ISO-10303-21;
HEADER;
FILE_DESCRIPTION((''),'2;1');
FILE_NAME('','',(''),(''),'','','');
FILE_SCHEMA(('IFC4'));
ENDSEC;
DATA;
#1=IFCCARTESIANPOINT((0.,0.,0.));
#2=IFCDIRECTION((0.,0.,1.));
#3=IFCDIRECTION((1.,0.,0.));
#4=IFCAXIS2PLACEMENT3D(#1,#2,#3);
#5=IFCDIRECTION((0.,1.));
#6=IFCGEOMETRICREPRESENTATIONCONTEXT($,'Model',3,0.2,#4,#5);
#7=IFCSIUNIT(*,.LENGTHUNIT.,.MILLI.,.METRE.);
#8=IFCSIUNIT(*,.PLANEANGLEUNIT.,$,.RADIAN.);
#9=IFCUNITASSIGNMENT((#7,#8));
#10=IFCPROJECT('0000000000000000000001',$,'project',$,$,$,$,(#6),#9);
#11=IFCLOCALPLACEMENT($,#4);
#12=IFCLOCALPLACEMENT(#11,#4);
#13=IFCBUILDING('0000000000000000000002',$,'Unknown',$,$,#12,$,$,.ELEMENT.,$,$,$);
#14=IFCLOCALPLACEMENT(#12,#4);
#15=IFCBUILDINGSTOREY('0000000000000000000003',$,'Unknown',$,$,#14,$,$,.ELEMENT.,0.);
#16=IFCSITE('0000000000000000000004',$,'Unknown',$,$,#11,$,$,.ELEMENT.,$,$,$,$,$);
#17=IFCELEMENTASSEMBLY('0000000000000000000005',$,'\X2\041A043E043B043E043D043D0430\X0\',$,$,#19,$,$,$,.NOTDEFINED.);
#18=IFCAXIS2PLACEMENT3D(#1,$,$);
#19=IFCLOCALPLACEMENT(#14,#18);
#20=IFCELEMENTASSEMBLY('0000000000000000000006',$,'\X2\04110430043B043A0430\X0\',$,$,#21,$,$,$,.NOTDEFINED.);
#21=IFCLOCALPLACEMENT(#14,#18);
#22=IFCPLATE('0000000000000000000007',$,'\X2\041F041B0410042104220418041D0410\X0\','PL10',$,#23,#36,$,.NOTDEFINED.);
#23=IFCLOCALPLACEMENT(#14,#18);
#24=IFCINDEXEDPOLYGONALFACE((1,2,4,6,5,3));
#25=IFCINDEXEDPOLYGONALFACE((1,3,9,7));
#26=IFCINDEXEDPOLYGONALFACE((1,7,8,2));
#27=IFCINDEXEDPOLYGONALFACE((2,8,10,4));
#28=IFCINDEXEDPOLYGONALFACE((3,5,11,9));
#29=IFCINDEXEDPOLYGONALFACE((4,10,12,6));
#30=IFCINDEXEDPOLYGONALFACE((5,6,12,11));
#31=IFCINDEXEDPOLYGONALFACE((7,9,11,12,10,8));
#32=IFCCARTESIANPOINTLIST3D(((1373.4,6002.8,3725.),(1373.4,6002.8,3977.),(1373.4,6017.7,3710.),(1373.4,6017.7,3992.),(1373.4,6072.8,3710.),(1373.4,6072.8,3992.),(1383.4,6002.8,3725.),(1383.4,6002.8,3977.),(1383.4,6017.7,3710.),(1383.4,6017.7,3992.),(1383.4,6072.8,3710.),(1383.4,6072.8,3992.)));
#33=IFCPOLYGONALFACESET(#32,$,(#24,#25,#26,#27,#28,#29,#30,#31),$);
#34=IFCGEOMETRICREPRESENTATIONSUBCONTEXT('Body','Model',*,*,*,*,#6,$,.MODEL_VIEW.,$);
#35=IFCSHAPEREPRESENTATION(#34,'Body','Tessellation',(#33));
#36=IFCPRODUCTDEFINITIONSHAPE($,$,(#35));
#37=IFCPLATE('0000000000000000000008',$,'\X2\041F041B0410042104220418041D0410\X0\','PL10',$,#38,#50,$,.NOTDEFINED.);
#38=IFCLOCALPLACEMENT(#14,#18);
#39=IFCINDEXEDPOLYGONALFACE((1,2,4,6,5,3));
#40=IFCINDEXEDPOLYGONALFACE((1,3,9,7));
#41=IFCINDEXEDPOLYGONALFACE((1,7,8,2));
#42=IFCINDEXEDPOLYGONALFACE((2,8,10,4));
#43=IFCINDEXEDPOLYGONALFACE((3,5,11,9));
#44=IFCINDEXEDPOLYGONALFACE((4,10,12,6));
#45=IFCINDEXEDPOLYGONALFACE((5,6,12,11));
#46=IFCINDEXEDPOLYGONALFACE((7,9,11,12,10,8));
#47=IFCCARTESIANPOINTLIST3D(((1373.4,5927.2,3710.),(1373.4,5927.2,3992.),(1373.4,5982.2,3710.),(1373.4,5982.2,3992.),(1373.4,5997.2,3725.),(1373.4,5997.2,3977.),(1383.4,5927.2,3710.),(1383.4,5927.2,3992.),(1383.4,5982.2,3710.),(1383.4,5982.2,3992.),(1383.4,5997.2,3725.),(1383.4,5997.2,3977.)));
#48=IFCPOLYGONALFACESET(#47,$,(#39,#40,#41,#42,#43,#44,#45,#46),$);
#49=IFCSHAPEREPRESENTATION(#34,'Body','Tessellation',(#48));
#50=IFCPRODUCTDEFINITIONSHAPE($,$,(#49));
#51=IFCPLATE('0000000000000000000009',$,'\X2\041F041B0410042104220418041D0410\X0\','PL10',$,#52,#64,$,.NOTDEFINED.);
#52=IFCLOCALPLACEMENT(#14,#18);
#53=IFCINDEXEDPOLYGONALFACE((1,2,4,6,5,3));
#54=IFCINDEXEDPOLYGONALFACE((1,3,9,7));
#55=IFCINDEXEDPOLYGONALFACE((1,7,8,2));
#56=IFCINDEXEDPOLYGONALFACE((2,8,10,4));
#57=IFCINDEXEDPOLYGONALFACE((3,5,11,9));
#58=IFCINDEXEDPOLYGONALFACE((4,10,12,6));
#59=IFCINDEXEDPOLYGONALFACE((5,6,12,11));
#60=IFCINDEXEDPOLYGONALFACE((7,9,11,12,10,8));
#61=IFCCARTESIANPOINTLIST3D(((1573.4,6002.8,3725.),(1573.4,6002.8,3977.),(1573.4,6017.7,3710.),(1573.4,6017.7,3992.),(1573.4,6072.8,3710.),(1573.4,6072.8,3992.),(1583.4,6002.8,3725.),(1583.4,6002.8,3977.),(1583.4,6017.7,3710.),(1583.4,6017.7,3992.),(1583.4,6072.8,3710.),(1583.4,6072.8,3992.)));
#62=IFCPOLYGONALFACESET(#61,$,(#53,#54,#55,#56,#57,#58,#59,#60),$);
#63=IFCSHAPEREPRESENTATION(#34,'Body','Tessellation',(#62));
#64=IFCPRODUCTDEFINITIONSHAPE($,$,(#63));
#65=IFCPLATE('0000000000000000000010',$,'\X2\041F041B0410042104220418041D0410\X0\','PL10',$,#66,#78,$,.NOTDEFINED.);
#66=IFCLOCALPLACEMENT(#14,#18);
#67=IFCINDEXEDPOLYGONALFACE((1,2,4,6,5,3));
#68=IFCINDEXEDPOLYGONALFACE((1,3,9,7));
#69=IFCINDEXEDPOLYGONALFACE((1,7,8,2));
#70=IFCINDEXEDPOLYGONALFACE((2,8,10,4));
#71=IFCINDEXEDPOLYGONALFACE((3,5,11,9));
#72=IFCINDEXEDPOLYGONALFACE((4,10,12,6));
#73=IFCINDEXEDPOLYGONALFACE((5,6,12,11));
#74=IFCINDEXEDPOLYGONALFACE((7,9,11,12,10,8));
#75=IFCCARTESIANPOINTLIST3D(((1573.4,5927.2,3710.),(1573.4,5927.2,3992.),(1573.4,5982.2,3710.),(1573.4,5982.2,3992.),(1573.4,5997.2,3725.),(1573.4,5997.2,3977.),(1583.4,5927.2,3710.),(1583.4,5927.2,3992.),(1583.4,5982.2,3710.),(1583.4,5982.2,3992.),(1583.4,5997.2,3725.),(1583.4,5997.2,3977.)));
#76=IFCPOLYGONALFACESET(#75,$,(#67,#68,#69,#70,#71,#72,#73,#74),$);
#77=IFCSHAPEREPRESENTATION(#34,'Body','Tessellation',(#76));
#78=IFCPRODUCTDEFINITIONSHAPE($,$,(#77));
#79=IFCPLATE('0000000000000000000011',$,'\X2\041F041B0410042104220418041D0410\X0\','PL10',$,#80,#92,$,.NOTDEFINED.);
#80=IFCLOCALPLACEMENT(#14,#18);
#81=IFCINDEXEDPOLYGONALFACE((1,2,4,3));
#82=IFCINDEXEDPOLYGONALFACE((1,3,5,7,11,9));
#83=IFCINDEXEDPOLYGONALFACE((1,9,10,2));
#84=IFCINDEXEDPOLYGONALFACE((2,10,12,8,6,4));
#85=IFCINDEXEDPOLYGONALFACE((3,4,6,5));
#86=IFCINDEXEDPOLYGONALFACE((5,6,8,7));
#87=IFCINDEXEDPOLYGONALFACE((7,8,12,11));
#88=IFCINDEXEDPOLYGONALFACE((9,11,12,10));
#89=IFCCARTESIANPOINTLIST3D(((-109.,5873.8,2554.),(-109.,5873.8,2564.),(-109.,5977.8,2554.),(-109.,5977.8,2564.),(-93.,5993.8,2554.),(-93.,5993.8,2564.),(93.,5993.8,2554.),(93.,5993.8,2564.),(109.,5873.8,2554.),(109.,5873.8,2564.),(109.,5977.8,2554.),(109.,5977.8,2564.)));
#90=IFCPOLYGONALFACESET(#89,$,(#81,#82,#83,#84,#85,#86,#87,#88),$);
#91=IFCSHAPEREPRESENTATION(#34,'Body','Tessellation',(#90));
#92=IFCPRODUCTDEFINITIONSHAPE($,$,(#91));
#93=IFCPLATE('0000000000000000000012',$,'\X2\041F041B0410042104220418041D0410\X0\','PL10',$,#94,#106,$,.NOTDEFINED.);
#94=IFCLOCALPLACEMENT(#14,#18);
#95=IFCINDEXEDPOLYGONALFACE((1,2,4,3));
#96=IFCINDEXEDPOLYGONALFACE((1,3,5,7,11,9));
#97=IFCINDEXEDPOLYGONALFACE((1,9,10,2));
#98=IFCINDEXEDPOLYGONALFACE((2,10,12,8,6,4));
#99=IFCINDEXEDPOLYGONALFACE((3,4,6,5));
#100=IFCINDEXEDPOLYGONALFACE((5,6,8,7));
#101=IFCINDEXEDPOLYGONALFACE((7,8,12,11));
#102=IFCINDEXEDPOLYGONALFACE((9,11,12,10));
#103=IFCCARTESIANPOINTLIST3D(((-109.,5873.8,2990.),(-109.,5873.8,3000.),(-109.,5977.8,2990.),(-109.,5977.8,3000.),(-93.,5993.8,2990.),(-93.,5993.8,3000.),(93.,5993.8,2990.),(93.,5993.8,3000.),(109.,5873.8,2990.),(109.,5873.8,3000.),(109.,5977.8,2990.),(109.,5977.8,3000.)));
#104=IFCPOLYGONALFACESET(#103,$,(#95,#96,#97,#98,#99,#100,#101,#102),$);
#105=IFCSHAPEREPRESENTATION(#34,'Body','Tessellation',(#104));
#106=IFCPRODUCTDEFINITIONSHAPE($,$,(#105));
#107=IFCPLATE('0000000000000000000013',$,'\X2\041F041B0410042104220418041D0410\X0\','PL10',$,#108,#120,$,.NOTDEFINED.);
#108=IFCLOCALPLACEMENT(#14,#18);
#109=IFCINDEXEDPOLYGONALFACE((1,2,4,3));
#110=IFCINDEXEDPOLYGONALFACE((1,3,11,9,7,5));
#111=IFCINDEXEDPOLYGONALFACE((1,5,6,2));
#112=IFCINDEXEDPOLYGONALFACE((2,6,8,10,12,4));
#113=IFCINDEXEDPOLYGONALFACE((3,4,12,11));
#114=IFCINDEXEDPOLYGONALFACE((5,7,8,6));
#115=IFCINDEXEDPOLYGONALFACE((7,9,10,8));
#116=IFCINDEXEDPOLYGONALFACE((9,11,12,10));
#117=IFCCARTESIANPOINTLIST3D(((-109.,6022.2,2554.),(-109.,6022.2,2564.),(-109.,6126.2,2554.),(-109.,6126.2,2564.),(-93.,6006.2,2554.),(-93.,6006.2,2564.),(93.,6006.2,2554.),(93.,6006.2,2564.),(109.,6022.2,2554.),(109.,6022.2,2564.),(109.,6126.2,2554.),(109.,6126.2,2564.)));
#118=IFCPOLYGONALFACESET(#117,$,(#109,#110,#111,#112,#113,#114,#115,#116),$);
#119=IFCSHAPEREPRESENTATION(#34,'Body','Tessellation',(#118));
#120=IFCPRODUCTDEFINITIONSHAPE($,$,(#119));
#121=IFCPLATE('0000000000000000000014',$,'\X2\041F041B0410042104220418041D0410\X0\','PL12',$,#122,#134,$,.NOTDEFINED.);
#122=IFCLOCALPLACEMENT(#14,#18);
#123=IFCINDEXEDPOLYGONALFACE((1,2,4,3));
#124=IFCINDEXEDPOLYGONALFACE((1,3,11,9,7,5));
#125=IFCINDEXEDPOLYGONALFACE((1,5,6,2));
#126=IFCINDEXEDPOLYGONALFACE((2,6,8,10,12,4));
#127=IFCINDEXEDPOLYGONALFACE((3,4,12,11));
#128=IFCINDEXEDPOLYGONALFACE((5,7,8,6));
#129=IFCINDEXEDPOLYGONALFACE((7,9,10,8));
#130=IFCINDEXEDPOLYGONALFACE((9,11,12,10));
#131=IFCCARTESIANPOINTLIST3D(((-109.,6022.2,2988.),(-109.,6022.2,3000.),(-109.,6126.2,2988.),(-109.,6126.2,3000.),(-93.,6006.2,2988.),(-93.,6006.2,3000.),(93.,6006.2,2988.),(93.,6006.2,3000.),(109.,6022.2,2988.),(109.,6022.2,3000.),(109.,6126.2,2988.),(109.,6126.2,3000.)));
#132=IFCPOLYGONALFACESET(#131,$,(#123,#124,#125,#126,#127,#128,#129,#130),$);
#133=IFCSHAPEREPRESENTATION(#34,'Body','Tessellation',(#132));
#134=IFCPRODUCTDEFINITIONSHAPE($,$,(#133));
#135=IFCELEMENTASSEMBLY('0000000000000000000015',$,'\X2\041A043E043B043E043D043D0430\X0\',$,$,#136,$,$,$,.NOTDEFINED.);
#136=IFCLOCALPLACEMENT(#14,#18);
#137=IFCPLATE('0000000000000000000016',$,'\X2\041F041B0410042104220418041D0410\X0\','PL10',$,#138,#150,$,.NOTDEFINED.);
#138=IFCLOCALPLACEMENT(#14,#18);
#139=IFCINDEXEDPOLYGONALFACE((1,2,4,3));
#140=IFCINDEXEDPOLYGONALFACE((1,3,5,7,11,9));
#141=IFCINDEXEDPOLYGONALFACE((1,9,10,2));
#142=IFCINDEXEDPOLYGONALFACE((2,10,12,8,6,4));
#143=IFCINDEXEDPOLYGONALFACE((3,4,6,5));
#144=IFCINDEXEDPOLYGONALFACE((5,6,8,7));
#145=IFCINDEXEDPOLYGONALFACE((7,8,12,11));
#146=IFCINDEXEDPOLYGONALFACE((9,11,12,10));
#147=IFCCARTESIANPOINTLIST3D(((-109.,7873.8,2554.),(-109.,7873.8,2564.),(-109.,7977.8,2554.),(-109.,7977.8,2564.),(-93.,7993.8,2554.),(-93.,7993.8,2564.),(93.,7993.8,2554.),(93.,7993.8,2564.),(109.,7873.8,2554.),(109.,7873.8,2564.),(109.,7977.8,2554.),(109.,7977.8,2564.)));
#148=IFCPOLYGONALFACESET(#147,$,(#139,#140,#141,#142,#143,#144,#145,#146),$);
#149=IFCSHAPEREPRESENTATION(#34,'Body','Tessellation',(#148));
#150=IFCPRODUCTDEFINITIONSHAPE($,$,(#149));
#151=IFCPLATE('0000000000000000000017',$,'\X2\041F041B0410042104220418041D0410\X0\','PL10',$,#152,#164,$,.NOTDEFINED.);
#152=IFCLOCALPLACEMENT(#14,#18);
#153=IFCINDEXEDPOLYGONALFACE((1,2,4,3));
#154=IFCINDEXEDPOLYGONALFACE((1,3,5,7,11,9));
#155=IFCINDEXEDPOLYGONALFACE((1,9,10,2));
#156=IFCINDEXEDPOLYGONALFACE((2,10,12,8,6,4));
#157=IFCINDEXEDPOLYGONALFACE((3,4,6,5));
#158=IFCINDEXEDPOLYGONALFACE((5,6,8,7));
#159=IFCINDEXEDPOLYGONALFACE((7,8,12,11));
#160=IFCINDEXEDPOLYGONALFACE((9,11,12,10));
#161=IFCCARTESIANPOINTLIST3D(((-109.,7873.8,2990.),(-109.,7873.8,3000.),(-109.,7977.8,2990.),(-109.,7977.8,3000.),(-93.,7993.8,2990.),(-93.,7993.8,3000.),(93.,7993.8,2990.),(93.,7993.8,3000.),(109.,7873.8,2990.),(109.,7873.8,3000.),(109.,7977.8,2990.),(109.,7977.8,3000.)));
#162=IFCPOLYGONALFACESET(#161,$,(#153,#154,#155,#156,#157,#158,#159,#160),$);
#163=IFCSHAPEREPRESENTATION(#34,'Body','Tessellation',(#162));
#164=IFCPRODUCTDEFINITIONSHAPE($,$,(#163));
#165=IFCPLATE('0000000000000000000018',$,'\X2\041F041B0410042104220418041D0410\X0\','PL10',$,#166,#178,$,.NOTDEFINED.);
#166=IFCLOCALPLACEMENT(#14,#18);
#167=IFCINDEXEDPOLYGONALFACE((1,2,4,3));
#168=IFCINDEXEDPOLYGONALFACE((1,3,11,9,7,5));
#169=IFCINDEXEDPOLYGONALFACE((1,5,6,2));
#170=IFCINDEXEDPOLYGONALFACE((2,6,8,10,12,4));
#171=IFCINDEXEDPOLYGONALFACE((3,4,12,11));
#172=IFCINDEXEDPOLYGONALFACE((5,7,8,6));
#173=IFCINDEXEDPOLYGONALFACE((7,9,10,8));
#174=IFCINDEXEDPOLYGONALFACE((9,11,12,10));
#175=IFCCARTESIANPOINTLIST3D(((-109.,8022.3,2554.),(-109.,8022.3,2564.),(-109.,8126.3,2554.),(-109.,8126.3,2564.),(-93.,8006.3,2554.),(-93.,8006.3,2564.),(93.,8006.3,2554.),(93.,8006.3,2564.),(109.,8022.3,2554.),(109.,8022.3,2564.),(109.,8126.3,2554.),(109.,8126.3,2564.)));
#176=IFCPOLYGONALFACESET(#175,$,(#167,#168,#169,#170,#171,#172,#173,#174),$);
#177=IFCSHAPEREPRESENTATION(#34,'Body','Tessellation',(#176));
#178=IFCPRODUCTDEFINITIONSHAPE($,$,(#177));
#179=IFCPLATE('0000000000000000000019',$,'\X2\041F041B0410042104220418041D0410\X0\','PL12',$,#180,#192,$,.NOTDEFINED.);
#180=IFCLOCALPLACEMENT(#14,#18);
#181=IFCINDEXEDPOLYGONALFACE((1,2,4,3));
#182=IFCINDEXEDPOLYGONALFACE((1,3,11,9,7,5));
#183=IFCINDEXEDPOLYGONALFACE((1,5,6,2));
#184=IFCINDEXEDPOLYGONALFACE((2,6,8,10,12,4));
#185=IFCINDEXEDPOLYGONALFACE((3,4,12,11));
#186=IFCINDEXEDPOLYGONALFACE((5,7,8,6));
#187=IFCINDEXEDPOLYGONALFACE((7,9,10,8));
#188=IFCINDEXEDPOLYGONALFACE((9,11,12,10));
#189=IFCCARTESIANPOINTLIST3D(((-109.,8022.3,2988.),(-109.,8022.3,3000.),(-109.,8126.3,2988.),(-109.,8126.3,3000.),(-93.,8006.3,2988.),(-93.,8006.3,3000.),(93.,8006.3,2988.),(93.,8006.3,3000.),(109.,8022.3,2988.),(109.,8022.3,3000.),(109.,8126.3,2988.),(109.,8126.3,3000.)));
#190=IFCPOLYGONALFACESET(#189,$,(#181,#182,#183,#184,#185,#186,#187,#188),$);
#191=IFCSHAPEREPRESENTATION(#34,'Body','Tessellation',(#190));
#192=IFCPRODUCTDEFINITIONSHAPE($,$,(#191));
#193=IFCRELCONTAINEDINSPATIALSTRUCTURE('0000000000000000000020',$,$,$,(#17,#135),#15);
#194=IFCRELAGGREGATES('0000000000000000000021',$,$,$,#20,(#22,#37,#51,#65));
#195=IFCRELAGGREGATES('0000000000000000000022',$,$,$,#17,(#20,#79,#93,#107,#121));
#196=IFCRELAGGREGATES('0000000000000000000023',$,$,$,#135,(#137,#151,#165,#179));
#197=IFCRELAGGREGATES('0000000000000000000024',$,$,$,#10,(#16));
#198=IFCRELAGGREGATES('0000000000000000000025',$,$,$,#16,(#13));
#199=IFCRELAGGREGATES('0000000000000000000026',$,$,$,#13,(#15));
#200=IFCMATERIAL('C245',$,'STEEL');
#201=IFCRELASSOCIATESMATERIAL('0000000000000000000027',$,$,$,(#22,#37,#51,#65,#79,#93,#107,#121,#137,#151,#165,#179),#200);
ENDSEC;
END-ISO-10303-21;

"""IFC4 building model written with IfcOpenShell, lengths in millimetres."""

from ifc_helpers import new_model, si_unit, direction, frame, origin_with_axes, place, context, subcontext, project, spatial, line, indexed_curve, outline, extrude, material, element, aggregate, save


model = new_model("IFC4")

# Units and contexts
model_context = context("Model", 3, precision=0.2, world=origin_with_axes(), true_north=direction((0.0, 1.0)))
body_context = subcontext(model_context, "Body", "Model", "MODEL_VIEW")
ifc_project = project(units=[si_unit("LENGTHUNIT", "METRE", prefix="MILLI"), si_unit("PLANEANGLEUNIT", "RADIAN")], contexts=[model_context])

# Site, building, storey
site_placement = place(None, origin_with_axes())
site = spatial("IfcSite", under=ifc_project, at=site_placement, Name="Unknown", CompositionType="ELEMENT")
building_placement = place(site_placement, origin_with_axes())
building = spatial("IfcBuilding", under=site, at=building_placement, Name="Unknown", CompositionType="ELEMENT")
storey_placement = place(building_placement, origin_with_axes())
storey = spatial("IfcBuildingStorey", under=building, at=storey_placement, Name="Unknown", CompositionType="ELEMENT", Elevation=0.0)

# Element assemblies, plates
assembly_1_placement = place(storey_placement, frame((0.0, 6000.0, 0.0), z_axis=(0.0, -1.0, 0.0), x_axis=(0.0, 0.0, 1.0)))
assembly_1 = element("IfcElementAssembly", 1, at=assembly_1_placement, inside=storey, Name="Колонна", PredefinedType="NOTDEFINED")
assembly_2_placement = place(assembly_1_placement, frame((3851.0, 0.0, 0.0), z_axis=(0.0, 0.0, 1.0), x_axis=(0.0, -1.0, 0.0)))
assembly_2 = element("IfcElementAssembly", 2, at=assembly_2_placement, Name="Балка", PredefinedType="NOTDEFINED")
ifc_material_1 = material(Name="C245", Category="STEEL")
plate_1_placement = place(assembly_2_placement, frame((1378.4, -141.0, -2.8), z_axis=(1.0, 0.0, 0.0), x_axis=(0.0, 0.0, -1.0)))
plate_1 = element("IfcPlate", 3, at=plate_1_placement, material=ifc_material_1, Name="ПЛАСТИНА", Description="PL10", PredefinedType="NOTDEFINED", context=body_context, shape_type="SolidModel", body=[
    extrude(outline(indexed_curve([(0.0, 15.0), (15.0, 0.0), (70.0, 0.0), (70.0, 282.0), (15.0, 282.0), (0.0, 267.0)], segments=[line(1, 2, 3, 4, 5, 6, 1)])), frame((0.0, 0.0, 5.0), z_axis=(0.0, 0.0, 1.0), x_axis=(1.0, 0.0, 0.0)), (0.0, 0.0, -1.0), 10.0),
])
plate_2_placement = place(assembly_2_placement, frame((1378.4, -141.0, 72.8), z_axis=(1.0, 0.0, 0.0), x_axis=(0.0, 0.0, -1.0)))
plate_2 = element("IfcPlate", 4, at=plate_2_placement, material=ifc_material_1, Name="ПЛАСТИНА", Description="PL10", PredefinedType="NOTDEFINED", context=body_context, shape_type="SolidModel", body=[
    extrude(outline(indexed_curve([(0.0, 0.0), (55.0, 0.0), (70.0, 15.0), (70.0, 267.0), (55.0, 282.0), (0.0, 282.0)], segments=[line(1, 2, 3, 4, 5, 6, 1)])), frame((0.0, 0.0, 5.0), z_axis=(0.0, 0.0, 1.0), x_axis=(1.0, 0.0, 0.0)), (0.0, 0.0, -1.0), 10.0),
])
plate_3_placement = place(assembly_2_placement, frame((1578.4, -141.0, -2.8), z_axis=(1.0, 0.0, 0.0), x_axis=(0.0, 0.0, -1.0)))
plate_3 = element("IfcPlate", 5, at=plate_3_placement, material=ifc_material_1, Name="ПЛАСТИНА", Description="PL10", PredefinedType="NOTDEFINED", context=body_context, shape_type="SolidModel", body=[
    extrude(outline(indexed_curve([(0.0, 15.0), (15.0, 0.0), (70.0, 0.0), (70.0, 282.0), (15.0, 282.0), (0.0, 267.0)], segments=[line(1, 2, 3, 4, 5, 6, 1)])), frame((0.0, 0.0, 5.0), z_axis=(0.0, 0.0, 1.0), x_axis=(1.0, 0.0, 0.0)), (0.0, 0.0, -1.0), 10.0),
])
plate_4_placement = place(assembly_2_placement, frame((1578.4, -141.0, 72.8), z_axis=(1.0, 0.0, 0.0), x_axis=(0.0, 0.0, -1.0)))
plate_4 = element("IfcPlate", 6, at=plate_4_placement, material=ifc_material_1, Name="ПЛАСТИНА", Description="PL10", PredefinedType="NOTDEFINED", context=body_context, shape_type="SolidModel", body=[
    extrude(outline(indexed_curve([(0.0, 0.0), (55.0, 0.0), (70.0, 15.0), (70.0, 267.0), (55.0, 282.0), (0.0, 282.0)], segments=[line(1, 2, 3, 4, 5, 6, 1)])), frame((0.0, 0.0, 5.0), z_axis=(0.0, 0.0, 1.0), x_axis=(1.0, 0.0, 0.0)), (0.0, 0.0, -1.0), 10.0),
])
aggregate(assembly_2, [plate_1, plate_2, plate_3, plate_4])
plate_5_placement = place(assembly_1_placement, frame((2559.0, -109.0, 6.2), z_axis=(-1.0, 0.0, 0.0), x_axis=(0.0, 0.0, 1.0)))
plate_5 = element("IfcPlate", 7, at=plate_5_placement, material=ifc_material_1, Name="ПЛАСТИНА", Description="PL10", PredefinedType="NOTDEFINED", context=body_context, shape_type="SolidModel", body=[
    extrude(outline(indexed_curve([(0.0, 16.0), (16.0, 0.0), (120.0, 0.0), (120.0, 218.0), (16.0, 218.0), (0.0, 202.0)], segments=[line(1, 2, 3, 4, 5, 6, 1)])), frame((0.0, 0.0, 5.0), z_axis=(0.0, 0.0, 1.0), x_axis=(1.0, 0.0, 0.0)), (0.0, 0.0, -1.0), 10.0),
])
plate_6_placement = place(assembly_1_placement, frame((2995.0, -109.0, 6.2), z_axis=(-1.0, 0.0, 0.0), x_axis=(0.0, 0.0, 1.0)))
plate_6 = element("IfcPlate", 8, at=plate_6_placement, material=ifc_material_1, Name="ПЛАСТИНА", Description="PL10", PredefinedType="NOTDEFINED", context=body_context, shape_type="SolidModel", body=[
    extrude(outline(indexed_curve([(0.0, 16.0), (16.0, 0.0), (120.0, 0.0), (120.0, 218.0), (16.0, 218.0), (0.0, 202.0)], segments=[line(1, 2, 3, 4, 5, 6, 1)])), frame((0.0, 0.0, 5.0), z_axis=(0.0, 0.0, 1.0), x_axis=(1.0, 0.0, 0.0)), (0.0, 0.0, -1.0), 10.0),
])
plate_7_placement = place(assembly_1_placement, frame((2559.0, -109.0, -126.2), z_axis=(-1.0, 0.0, 0.0), x_axis=(0.0, 0.0, 1.0)))
plate_7 = element("IfcPlate", 9, at=plate_7_placement, material=ifc_material_1, Name="ПЛАСТИНА", Description="PL10", PredefinedType="NOTDEFINED", context=body_context, shape_type="SolidModel", body=[
    extrude(outline(indexed_curve([(0.0, 0.0), (104.0, 0.0), (120.0, 16.0), (120.0, 202.0), (104.0, 218.0), (0.0, 218.0)], segments=[line(1, 2, 3, 4, 5, 6, 1)])), frame((0.0, 0.0, 5.0), z_axis=(0.0, 0.0, 1.0), x_axis=(1.0, 0.0, 0.0)), (0.0, 0.0, -1.0), 10.0),
])
plate_8_placement = place(assembly_1_placement, frame((2994.0, -109.0, -126.2), z_axis=(-1.0, 0.0, 0.0), x_axis=(0.0, 0.0, 1.0)))
plate_8 = element("IfcPlate", 10, at=plate_8_placement, material=ifc_material_1, Name="ПЛАСТИНА", Description="PL12", PredefinedType="NOTDEFINED", context=body_context, shape_type="SolidModel", body=[
    extrude(outline(indexed_curve([(0.0, 0.0), (104.0, 0.0), (120.0, 16.0), (120.0, 202.0), (104.0, 218.0), (0.0, 218.0)], segments=[line(1, 2, 3, 4, 5, 6, 1)])), frame((0.0, 0.0, 6.0), z_axis=(0.0, 0.0, 1.0), x_axis=(1.0, 0.0, 0.0)), (0.0, 0.0, -1.0), 12.0),
])
assembly_3_placement = place(storey_placement, frame((0.0, 8000.0, 0.0), z_axis=(0.0, -1.0, 0.0), x_axis=(0.0, 0.0, 1.0)))
assembly_3 = element("IfcElementAssembly", 11, at=assembly_3_placement, inside=storey, Name="Колонна", PredefinedType="NOTDEFINED")
plate_9_placement = place(assembly_3_placement, frame((2559.0, -109.0, 6.2), z_axis=(-1.0, 0.0, 0.0), x_axis=(0.0, 0.0, 1.0)))
plate_9 = element("IfcPlate", 12, at=plate_9_placement, material=ifc_material_1, Name="ПЛАСТИНА", Description="PL10", PredefinedType="NOTDEFINED", context=body_context, shape_type="SolidModel", body=[
    extrude(outline(indexed_curve([(0.0, 16.0), (16.0, 0.0), (120.0, 0.0), (120.0, 218.0), (16.0, 218.0), (0.0, 202.0)], segments=[line(1, 2, 3, 4, 5, 6, 1)])), frame((0.0, 0.0, 5.0), z_axis=(0.0, 0.0, 1.0), x_axis=(1.0, 0.0, 0.0)), (0.0, 0.0, -1.0), 10.0),
])
plate_10_placement = place(assembly_3_placement, frame((2995.0, -109.0, 6.2), z_axis=(-1.0, 0.0, 0.0), x_axis=(0.0, 0.0, 1.0)))
plate_10 = element("IfcPlate", 13, at=plate_10_placement, material=ifc_material_1, Name="ПЛАСТИНА", Description="PL10", PredefinedType="NOTDEFINED", context=body_context, shape_type="SolidModel", body=[
    extrude(outline(indexed_curve([(0.0, 16.0), (16.0, 0.0), (120.0, 0.0), (120.0, 218.0), (16.0, 218.0), (0.0, 202.0)], segments=[line(1, 2, 3, 4, 5, 6, 1)])), frame((0.0, 0.0, 5.0), z_axis=(0.0, 0.0, 1.0), x_axis=(1.0, 0.0, 0.0)), (0.0, 0.0, -1.0), 10.0),
])
plate_11_placement = place(assembly_3_placement, frame((2559.0, -109.0, -126.2), z_axis=(-1.0, 0.0, 0.0), x_axis=(0.0, 0.0, 1.0)))
plate_11 = element("IfcPlate", 14, at=plate_11_placement, material=ifc_material_1, Name="ПЛАСТИНА", Description="PL10", PredefinedType="NOTDEFINED", context=body_context, shape_type="SolidModel", body=[
    extrude(outline(indexed_curve([(0.0, 0.0), (104.0, 0.0), (120.0, 16.0), (120.0, 202.0), (104.0, 218.0), (0.0, 218.0)], segments=[line(1, 2, 3, 4, 5, 6, 1)])), frame((0.0, 0.0, 5.0), z_axis=(0.0, 0.0, 1.0), x_axis=(1.0, 0.0, 0.0)), (0.0, 0.0, -1.0), 10.0),
])
plate_12_placement = place(assembly_3_placement, frame((2994.0, -109.0, -126.2), z_axis=(-1.0, 0.0, 0.0), x_axis=(0.0, 0.0, 1.0)))
plate_12 = element("IfcPlate", 15, at=plate_12_placement, material=ifc_material_1, Name="ПЛАСТИНА", Description="PL12", PredefinedType="NOTDEFINED", context=body_context, shape_type="SolidModel", body=[
    extrude(outline(indexed_curve([(0.0, 0.0), (104.0, 0.0), (120.0, 16.0), (120.0, 202.0), (104.0, 218.0), (0.0, 218.0)], segments=[line(1, 2, 3, 4, 5, 6, 1)])), frame((0.0, 0.0, 6.0), z_axis=(0.0, 0.0, 1.0), x_axis=(1.0, 0.0, 0.0)), (0.0, 0.0, -1.0), 12.0),
])

aggregate(assembly_1, [assembly_2, plate_5, plate_6, plate_7, plate_8])
aggregate(assembly_3, [plate_9, plate_10, plate_11, plate_12])

save(model, "model.ifc")
